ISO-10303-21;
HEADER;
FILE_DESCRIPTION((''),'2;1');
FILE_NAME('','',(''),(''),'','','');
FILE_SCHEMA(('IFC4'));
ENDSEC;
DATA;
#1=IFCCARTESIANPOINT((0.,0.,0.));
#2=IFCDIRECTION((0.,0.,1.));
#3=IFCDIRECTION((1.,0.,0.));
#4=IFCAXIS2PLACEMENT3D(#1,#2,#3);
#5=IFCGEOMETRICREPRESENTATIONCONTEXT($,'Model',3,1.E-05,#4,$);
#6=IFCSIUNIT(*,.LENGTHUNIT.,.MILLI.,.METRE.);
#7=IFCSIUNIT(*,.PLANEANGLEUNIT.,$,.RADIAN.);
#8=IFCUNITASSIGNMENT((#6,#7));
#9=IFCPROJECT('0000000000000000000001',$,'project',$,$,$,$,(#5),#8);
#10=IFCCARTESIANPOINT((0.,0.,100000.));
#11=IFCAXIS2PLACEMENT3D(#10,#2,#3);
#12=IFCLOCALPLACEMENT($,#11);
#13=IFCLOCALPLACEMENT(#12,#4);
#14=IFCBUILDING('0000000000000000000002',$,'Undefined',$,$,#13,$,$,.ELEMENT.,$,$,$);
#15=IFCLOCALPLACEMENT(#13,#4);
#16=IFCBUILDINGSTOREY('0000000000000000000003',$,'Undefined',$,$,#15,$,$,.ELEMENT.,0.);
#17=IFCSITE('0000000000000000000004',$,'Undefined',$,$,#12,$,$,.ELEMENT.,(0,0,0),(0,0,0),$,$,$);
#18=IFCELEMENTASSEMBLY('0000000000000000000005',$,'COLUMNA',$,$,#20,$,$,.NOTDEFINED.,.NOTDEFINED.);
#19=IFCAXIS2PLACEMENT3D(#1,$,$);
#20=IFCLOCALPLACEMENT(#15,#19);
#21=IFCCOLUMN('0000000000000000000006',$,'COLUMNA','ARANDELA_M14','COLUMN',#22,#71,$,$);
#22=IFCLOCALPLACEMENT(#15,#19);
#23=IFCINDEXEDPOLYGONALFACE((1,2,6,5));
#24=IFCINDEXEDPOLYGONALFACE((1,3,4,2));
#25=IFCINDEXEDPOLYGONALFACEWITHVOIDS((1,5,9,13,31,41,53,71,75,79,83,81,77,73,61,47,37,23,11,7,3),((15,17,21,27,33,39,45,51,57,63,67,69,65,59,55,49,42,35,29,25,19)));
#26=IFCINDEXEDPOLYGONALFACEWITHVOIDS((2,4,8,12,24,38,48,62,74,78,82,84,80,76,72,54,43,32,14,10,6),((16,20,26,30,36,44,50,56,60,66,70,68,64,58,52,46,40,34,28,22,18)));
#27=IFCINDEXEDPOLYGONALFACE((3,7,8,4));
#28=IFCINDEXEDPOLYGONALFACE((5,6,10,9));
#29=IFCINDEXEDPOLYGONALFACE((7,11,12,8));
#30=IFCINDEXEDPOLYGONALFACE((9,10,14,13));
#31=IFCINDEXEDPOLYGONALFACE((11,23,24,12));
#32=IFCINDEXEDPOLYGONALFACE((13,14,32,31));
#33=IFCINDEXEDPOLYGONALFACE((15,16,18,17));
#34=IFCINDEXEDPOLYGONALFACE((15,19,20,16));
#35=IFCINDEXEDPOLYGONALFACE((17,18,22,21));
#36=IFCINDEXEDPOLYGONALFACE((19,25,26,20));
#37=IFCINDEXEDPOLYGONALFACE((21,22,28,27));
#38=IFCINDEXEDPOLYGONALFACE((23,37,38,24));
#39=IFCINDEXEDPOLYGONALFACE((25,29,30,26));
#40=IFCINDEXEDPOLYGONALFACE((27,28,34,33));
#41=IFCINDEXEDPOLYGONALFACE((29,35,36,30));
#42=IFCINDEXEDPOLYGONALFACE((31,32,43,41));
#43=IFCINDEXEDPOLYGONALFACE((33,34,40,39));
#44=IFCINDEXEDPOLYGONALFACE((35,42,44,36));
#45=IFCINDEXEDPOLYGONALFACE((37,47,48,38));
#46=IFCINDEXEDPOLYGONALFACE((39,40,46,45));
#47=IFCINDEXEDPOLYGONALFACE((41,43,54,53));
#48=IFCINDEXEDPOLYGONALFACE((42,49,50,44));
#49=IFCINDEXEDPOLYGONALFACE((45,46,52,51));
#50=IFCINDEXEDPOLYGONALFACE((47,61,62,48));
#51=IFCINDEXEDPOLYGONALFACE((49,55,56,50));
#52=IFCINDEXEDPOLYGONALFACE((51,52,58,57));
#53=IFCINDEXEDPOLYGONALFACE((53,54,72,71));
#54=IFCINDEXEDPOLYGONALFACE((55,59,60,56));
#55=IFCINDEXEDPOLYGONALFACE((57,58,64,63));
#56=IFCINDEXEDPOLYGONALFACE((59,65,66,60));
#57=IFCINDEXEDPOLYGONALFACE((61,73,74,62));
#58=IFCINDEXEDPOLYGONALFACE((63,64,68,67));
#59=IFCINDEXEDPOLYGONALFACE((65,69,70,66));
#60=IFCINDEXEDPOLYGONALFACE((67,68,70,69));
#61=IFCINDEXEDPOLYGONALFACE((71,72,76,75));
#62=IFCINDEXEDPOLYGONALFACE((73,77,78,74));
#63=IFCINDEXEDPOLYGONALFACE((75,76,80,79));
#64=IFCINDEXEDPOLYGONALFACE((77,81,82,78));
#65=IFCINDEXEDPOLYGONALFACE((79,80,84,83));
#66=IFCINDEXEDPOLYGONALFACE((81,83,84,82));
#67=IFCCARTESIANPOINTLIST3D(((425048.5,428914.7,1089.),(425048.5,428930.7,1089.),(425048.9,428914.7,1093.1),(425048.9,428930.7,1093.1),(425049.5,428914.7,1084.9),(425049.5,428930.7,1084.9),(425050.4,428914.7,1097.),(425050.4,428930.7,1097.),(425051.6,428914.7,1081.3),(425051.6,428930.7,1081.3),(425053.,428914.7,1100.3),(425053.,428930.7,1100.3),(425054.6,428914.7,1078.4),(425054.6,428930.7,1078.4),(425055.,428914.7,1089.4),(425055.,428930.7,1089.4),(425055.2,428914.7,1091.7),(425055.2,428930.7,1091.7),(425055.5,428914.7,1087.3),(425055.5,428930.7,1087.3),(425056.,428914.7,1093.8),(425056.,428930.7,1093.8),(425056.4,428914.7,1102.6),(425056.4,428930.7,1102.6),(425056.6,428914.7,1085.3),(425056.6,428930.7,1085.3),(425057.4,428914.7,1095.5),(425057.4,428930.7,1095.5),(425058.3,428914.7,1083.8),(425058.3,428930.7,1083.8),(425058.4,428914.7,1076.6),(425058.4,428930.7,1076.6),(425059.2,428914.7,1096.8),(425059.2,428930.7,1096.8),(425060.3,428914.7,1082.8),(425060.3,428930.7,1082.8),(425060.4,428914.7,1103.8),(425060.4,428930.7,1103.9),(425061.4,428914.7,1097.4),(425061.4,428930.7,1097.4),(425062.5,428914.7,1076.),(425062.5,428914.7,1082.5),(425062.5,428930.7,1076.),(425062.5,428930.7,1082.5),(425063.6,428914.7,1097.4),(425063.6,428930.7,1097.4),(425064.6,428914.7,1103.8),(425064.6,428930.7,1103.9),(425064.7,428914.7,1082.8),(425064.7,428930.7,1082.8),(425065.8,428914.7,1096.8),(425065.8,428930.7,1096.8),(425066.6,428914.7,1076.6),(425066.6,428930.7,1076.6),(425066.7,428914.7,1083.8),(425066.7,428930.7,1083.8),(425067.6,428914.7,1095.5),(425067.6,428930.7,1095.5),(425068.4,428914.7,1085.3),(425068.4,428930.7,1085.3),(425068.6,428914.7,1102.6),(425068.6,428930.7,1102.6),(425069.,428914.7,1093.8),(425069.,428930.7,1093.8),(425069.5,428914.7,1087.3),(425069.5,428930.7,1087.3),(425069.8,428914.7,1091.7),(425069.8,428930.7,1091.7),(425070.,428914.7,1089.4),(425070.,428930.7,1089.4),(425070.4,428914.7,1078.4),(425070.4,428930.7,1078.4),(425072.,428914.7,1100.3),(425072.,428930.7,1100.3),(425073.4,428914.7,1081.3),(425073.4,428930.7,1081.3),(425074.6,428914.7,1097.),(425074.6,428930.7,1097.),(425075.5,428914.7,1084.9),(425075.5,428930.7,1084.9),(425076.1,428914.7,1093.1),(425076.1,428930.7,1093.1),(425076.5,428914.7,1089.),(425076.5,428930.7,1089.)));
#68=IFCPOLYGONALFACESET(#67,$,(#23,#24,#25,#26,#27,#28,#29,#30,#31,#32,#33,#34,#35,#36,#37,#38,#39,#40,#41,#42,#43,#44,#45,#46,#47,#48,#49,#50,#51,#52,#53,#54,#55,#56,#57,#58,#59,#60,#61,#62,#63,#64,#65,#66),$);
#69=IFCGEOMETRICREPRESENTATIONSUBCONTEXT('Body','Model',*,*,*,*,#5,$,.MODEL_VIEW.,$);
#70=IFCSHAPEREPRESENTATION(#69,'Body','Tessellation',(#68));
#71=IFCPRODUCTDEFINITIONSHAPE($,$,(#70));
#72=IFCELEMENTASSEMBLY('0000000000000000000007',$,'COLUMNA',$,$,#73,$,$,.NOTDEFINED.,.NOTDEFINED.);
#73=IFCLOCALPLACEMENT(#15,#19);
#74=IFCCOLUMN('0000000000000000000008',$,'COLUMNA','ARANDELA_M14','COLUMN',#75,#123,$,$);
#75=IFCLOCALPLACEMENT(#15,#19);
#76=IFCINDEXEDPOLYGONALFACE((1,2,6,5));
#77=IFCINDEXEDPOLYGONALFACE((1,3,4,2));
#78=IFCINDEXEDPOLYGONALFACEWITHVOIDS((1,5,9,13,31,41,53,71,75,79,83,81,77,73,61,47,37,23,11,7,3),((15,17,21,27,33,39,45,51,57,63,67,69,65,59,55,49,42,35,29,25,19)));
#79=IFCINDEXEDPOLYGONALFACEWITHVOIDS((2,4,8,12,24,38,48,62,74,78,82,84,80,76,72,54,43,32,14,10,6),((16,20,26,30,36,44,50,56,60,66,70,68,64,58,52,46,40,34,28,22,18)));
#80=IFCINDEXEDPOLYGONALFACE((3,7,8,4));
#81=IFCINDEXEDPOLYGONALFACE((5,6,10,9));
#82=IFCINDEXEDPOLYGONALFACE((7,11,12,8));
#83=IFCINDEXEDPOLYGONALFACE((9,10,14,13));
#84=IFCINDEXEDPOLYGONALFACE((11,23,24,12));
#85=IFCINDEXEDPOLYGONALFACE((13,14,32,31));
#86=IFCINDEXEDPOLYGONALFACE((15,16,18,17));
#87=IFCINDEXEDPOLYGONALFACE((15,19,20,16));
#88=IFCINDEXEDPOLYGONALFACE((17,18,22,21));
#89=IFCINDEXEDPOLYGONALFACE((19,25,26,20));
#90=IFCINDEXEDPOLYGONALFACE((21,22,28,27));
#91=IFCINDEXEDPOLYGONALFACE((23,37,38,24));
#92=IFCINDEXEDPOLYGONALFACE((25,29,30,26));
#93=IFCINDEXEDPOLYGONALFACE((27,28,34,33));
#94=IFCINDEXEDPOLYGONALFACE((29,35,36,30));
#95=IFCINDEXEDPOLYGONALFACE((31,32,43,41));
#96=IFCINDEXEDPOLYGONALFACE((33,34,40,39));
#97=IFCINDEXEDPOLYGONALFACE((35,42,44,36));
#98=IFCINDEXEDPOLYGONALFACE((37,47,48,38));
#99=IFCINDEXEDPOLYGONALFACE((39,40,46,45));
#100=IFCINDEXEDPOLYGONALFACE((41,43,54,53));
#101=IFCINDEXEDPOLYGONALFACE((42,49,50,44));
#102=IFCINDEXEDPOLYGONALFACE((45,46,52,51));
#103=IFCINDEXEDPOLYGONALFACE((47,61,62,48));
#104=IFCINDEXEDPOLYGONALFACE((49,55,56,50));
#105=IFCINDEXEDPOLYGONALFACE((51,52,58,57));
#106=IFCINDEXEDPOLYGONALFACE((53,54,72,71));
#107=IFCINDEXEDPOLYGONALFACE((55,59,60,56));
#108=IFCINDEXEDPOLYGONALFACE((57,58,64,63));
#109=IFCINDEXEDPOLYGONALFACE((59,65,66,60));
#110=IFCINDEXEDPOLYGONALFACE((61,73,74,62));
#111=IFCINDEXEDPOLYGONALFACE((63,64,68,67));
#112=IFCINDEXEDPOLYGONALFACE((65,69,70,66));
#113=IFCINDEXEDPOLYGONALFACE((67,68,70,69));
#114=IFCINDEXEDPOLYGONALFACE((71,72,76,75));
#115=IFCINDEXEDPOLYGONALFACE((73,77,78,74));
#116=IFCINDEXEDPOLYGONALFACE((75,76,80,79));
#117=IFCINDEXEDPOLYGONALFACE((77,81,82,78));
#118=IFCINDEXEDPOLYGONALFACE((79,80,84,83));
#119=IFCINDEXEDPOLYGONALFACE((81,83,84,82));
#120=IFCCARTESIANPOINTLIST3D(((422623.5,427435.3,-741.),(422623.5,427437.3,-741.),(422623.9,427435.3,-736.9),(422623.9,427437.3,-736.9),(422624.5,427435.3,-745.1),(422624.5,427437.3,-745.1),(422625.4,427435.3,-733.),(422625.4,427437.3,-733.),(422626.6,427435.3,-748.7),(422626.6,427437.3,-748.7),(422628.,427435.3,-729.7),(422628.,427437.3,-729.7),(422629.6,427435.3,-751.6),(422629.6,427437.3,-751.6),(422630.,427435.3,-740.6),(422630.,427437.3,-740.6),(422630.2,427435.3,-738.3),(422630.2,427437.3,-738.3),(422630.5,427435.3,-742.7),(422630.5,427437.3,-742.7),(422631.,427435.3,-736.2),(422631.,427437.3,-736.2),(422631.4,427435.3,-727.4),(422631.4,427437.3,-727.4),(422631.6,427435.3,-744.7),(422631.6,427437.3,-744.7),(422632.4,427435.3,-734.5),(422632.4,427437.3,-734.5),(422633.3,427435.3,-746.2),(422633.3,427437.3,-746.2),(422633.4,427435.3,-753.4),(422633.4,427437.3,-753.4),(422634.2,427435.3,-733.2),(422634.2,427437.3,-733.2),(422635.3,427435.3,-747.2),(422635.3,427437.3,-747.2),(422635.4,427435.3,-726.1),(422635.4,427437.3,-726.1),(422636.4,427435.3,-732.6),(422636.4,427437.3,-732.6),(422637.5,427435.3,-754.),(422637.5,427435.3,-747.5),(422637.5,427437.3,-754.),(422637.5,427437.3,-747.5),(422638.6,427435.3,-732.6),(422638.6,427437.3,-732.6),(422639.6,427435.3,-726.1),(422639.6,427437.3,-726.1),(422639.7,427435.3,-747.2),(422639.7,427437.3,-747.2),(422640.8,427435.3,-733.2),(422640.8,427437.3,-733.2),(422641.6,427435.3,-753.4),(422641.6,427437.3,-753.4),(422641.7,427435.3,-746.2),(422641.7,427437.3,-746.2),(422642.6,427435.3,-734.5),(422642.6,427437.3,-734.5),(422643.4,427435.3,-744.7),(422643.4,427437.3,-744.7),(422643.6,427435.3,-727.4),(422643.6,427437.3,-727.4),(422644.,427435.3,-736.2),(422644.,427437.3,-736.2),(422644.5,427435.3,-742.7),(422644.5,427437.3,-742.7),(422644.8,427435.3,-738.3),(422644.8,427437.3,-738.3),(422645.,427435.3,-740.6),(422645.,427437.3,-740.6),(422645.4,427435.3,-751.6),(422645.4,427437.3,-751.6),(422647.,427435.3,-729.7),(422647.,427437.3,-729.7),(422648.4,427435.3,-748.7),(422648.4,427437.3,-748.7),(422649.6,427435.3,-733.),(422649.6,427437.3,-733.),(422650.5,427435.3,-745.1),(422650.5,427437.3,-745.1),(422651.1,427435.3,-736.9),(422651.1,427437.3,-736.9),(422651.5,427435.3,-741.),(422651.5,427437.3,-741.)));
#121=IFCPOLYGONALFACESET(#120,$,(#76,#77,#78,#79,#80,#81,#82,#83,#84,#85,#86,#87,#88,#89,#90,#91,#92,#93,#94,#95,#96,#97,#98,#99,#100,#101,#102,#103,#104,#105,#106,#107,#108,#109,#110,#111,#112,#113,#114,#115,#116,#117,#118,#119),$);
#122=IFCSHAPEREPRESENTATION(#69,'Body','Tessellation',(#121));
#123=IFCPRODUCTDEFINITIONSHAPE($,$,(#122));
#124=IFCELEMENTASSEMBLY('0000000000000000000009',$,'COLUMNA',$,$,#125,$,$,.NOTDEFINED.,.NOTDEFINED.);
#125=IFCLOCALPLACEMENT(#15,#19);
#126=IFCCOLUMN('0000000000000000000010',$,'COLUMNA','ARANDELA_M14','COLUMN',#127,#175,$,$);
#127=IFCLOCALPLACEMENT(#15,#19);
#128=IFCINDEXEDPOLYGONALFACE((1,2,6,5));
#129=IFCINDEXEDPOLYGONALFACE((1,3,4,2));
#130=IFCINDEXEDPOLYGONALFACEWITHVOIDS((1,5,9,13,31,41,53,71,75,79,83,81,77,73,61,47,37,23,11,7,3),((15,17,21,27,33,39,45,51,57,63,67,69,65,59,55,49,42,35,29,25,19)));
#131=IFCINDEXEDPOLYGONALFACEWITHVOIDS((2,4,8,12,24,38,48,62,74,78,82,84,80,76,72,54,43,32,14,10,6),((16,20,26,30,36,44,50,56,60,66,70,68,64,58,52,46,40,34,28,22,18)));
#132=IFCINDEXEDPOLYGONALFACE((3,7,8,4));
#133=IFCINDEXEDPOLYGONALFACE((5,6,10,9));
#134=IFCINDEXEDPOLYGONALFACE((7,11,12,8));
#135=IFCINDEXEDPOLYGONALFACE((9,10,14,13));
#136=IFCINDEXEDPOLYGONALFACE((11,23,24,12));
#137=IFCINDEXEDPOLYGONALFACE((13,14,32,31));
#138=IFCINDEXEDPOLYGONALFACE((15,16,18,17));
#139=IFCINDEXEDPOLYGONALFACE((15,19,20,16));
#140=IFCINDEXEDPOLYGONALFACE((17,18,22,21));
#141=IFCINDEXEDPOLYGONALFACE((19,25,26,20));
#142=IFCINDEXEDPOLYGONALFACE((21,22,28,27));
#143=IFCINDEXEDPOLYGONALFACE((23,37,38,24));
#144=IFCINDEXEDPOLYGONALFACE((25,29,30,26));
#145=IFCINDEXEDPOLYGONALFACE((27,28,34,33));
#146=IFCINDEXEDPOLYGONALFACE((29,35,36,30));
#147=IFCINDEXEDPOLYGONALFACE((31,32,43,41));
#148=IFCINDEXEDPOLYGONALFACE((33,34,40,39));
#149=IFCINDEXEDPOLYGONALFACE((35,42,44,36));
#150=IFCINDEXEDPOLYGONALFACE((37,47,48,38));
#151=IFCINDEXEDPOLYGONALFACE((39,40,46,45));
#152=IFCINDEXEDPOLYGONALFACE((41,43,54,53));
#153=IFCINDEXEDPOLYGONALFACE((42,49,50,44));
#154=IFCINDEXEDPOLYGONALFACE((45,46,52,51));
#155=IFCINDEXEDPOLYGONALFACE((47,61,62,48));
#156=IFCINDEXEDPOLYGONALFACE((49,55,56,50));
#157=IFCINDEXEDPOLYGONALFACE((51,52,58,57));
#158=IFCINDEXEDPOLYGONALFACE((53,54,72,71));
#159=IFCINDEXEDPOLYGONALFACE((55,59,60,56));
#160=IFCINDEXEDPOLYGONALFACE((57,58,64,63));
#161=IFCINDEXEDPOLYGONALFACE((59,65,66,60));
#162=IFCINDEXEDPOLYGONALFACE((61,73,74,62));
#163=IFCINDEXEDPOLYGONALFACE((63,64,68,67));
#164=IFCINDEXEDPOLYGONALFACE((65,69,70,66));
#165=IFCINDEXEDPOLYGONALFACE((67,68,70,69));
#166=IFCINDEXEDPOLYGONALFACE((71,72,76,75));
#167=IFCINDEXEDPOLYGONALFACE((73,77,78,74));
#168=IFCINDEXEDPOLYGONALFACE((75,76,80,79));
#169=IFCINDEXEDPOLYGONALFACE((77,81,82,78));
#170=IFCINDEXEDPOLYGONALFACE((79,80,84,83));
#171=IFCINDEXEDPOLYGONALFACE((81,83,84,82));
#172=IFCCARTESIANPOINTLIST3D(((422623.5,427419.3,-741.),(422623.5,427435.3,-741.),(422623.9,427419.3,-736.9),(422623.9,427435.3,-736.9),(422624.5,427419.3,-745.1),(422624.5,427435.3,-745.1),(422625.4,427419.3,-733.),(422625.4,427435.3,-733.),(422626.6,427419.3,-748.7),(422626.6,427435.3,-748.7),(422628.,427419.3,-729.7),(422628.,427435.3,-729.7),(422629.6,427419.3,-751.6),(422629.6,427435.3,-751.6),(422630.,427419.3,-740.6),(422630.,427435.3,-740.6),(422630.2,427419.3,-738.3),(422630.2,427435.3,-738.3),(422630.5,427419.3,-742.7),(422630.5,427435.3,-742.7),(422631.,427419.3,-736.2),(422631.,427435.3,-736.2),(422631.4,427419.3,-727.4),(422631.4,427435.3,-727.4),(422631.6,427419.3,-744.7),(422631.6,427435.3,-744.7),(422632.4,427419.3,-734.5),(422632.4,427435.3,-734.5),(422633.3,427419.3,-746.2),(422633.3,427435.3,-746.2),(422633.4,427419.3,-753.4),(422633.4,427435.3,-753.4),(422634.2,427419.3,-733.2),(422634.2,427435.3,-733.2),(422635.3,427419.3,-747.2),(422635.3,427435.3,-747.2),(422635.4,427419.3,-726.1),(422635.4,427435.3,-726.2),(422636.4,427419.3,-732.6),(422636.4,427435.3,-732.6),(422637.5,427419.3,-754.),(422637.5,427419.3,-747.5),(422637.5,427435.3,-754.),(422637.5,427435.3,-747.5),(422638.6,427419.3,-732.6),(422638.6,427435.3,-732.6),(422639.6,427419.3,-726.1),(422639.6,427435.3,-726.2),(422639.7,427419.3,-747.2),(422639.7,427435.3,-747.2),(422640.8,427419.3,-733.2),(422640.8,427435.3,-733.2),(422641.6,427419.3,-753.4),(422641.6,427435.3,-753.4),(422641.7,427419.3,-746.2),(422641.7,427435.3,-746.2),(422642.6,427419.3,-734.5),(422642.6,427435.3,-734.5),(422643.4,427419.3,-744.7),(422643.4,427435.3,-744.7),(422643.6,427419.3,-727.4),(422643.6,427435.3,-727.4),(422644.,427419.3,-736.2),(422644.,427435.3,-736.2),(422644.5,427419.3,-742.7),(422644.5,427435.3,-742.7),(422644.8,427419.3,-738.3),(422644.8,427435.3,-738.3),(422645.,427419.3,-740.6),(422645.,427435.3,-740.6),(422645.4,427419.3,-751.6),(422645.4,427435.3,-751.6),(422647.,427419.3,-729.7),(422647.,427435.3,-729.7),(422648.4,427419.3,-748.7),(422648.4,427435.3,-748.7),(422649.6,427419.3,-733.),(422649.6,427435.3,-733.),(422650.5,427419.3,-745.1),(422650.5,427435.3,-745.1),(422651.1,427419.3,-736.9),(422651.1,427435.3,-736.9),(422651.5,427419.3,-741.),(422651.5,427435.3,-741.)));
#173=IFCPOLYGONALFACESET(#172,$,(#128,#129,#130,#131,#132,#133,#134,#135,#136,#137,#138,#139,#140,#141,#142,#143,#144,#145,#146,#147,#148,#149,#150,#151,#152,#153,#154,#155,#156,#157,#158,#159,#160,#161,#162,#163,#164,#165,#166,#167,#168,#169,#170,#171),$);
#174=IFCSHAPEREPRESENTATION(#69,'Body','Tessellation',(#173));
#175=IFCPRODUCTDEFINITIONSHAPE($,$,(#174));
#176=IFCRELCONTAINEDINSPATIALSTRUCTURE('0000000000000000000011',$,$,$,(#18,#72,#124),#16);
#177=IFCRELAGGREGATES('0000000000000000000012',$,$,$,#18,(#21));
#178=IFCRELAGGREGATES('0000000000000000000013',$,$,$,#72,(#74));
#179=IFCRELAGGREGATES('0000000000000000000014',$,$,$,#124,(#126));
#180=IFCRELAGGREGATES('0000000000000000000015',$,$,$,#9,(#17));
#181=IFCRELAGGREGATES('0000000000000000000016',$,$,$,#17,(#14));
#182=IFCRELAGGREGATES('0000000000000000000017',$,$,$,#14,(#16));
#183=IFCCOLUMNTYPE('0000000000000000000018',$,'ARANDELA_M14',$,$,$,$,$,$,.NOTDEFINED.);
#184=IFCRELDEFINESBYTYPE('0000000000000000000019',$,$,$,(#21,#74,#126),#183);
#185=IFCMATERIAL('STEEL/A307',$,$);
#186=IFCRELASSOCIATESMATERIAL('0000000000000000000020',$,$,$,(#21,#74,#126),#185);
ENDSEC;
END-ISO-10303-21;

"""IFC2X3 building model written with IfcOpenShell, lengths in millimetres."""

from ifc_helpers import new_model, si_unit, frame, origin_with_axes, origin_2d_with_axis, place, context, subcontext, project, spatial, hollow_circle, extrude, material, type_object, element, aggregate, save


model = new_model("IFC2X3")

# Units and contexts
model_context = context("Model", 3, precision=1e-05, world=origin_with_axes())
body_context = subcontext(model_context, "Body", "Model", "MODEL_VIEW")
ifc_project = project(units=[si_unit("LENGTHUNIT", "METRE", prefix="MILLI"), si_unit("PLANEANGLEUNIT", "RADIAN")], contexts=[model_context])

# Site, building, storey
site_placement = place(None, frame((0.0, 0.0, 100000.0), z_axis=(0.0, 0.0, 1.0), x_axis=(1.0, 0.0, 0.0)))
site = spatial("IfcSite", under=ifc_project, at=site_placement, Name="Undefined", CompositionType="ELEMENT", RefLatitude=(0, 0, 0), RefLongitude=(0, 0, 0))
building_placement = place(site_placement, origin_with_axes())
building = spatial("IfcBuilding", under=site, at=building_placement, Name="Undefined", CompositionType="ELEMENT")
storey_placement = place(building_placement, origin_with_axes())
storey = spatial("IfcBuildingStorey", under=building, at=storey_placement, Name="Undefined", CompositionType="ELEMENT", Elevation=0.0)

# Element assemblies, columns
ifc_material = material(Name="STEEL/A307")
column_type_1 = type_object("IfcColumnType", Name="ARANDELA_M14", PredefinedType="NOTDEFINED")
assembly_1_placement = place(storey_placement, origin_with_axes())
assembly_1 = element("IfcElementAssembly", 1, at=assembly_1_placement, inside=storey, Name="COLUMNA", AssemblyPlace="NOTDEFINED", PredefinedType="NOTDEFINED")
column_1_placement = place(assembly_1_placement, frame((425062.5, 428914.7, 1090.0), z_axis=(0.0, 1.0, 0.000285), x_axis=(1.0, 0.0, 0.0)))
column_1 = element("IfcColumn", 2, at=column_1_placement, type_object=column_type_1, material=ifc_material, Name="COLUMNA", Description="ARANDELA_M14", ObjectType="COLUMN", context=body_context, shape_type="SweptSolid", body=[
    extrude(hollow_circle(Radius=14.0, WallThickness=6.5, at=origin_2d_with_axis()), frame((0.0, 0.0, 16.0), z_axis=(0.0, 0.0, -1.0), x_axis=(0.0, 1.0, 0.0)), (0.0, 0.0, 1.0), 16.0),
])
aggregate(assembly_1, [column_1])
assembly_2_placement = place(storey_placement, origin_with_axes())
assembly_2 = element("IfcElementAssembly", 3, at=assembly_2_placement, inside=storey, Name="COLUMNA", AssemblyPlace="NOTDEFINED", PredefinedType="NOTDEFINED")
column_2_placement = place(assembly_2_placement, frame((422637.5, 427437.3, -740.0), z_axis=(0.0, -1.0, 0.000285), x_axis=(-1.0, 0.0, 0.0)))
column_2 = element("IfcColumn", 4, at=column_2_placement, type_object=column_type_1, material=ifc_material, Name="COLUMNA", Description="ARANDELA_M14", ObjectType="COLUMN", context=body_context, shape_type="SweptSolid", body=[
    extrude(hollow_circle(Radius=14.0, WallThickness=6.5, at=origin_2d_with_axis()), frame((0.0, 0.0, 2.0), z_axis=(0.0, 0.0, -1.0), x_axis=(0.0, 1.0, 0.0)), (0.0, 0.0, 1.0), 2.0),
])
aggregate(assembly_2, [column_2])
assembly_3_placement = place(storey_placement, origin_with_axes())
assembly_3 = element("IfcElementAssembly", 5, at=assembly_3_placement, inside=storey, Name="COLUMNA", AssemblyPlace="NOTDEFINED", PredefinedType="NOTDEFINED")
column_3_placement = place(assembly_3_placement, frame((422637.5, 427435.3, -740.0), z_axis=(0.0, -1.0, 0.000285), x_axis=(-1.0, 0.0, 0.0)))
column_3 = element("IfcColumn", 6, at=column_3_placement, type_object=column_type_1, material=ifc_material, Name="COLUMNA", Description="ARANDELA_M14", ObjectType="COLUMN", context=body_context, shape_type="SweptSolid", body=[
    extrude(hollow_circle(Radius=14.0, WallThickness=6.5, at=origin_2d_with_axis()), frame((0.0, 0.0, 16.0), z_axis=(0.0, 0.0, -1.0), x_axis=(0.0, 1.0, 0.0)), (0.0, 0.0, 1.0), 16.0),
])
aggregate(assembly_3, [column_3])

save(model, "model.ifc")
